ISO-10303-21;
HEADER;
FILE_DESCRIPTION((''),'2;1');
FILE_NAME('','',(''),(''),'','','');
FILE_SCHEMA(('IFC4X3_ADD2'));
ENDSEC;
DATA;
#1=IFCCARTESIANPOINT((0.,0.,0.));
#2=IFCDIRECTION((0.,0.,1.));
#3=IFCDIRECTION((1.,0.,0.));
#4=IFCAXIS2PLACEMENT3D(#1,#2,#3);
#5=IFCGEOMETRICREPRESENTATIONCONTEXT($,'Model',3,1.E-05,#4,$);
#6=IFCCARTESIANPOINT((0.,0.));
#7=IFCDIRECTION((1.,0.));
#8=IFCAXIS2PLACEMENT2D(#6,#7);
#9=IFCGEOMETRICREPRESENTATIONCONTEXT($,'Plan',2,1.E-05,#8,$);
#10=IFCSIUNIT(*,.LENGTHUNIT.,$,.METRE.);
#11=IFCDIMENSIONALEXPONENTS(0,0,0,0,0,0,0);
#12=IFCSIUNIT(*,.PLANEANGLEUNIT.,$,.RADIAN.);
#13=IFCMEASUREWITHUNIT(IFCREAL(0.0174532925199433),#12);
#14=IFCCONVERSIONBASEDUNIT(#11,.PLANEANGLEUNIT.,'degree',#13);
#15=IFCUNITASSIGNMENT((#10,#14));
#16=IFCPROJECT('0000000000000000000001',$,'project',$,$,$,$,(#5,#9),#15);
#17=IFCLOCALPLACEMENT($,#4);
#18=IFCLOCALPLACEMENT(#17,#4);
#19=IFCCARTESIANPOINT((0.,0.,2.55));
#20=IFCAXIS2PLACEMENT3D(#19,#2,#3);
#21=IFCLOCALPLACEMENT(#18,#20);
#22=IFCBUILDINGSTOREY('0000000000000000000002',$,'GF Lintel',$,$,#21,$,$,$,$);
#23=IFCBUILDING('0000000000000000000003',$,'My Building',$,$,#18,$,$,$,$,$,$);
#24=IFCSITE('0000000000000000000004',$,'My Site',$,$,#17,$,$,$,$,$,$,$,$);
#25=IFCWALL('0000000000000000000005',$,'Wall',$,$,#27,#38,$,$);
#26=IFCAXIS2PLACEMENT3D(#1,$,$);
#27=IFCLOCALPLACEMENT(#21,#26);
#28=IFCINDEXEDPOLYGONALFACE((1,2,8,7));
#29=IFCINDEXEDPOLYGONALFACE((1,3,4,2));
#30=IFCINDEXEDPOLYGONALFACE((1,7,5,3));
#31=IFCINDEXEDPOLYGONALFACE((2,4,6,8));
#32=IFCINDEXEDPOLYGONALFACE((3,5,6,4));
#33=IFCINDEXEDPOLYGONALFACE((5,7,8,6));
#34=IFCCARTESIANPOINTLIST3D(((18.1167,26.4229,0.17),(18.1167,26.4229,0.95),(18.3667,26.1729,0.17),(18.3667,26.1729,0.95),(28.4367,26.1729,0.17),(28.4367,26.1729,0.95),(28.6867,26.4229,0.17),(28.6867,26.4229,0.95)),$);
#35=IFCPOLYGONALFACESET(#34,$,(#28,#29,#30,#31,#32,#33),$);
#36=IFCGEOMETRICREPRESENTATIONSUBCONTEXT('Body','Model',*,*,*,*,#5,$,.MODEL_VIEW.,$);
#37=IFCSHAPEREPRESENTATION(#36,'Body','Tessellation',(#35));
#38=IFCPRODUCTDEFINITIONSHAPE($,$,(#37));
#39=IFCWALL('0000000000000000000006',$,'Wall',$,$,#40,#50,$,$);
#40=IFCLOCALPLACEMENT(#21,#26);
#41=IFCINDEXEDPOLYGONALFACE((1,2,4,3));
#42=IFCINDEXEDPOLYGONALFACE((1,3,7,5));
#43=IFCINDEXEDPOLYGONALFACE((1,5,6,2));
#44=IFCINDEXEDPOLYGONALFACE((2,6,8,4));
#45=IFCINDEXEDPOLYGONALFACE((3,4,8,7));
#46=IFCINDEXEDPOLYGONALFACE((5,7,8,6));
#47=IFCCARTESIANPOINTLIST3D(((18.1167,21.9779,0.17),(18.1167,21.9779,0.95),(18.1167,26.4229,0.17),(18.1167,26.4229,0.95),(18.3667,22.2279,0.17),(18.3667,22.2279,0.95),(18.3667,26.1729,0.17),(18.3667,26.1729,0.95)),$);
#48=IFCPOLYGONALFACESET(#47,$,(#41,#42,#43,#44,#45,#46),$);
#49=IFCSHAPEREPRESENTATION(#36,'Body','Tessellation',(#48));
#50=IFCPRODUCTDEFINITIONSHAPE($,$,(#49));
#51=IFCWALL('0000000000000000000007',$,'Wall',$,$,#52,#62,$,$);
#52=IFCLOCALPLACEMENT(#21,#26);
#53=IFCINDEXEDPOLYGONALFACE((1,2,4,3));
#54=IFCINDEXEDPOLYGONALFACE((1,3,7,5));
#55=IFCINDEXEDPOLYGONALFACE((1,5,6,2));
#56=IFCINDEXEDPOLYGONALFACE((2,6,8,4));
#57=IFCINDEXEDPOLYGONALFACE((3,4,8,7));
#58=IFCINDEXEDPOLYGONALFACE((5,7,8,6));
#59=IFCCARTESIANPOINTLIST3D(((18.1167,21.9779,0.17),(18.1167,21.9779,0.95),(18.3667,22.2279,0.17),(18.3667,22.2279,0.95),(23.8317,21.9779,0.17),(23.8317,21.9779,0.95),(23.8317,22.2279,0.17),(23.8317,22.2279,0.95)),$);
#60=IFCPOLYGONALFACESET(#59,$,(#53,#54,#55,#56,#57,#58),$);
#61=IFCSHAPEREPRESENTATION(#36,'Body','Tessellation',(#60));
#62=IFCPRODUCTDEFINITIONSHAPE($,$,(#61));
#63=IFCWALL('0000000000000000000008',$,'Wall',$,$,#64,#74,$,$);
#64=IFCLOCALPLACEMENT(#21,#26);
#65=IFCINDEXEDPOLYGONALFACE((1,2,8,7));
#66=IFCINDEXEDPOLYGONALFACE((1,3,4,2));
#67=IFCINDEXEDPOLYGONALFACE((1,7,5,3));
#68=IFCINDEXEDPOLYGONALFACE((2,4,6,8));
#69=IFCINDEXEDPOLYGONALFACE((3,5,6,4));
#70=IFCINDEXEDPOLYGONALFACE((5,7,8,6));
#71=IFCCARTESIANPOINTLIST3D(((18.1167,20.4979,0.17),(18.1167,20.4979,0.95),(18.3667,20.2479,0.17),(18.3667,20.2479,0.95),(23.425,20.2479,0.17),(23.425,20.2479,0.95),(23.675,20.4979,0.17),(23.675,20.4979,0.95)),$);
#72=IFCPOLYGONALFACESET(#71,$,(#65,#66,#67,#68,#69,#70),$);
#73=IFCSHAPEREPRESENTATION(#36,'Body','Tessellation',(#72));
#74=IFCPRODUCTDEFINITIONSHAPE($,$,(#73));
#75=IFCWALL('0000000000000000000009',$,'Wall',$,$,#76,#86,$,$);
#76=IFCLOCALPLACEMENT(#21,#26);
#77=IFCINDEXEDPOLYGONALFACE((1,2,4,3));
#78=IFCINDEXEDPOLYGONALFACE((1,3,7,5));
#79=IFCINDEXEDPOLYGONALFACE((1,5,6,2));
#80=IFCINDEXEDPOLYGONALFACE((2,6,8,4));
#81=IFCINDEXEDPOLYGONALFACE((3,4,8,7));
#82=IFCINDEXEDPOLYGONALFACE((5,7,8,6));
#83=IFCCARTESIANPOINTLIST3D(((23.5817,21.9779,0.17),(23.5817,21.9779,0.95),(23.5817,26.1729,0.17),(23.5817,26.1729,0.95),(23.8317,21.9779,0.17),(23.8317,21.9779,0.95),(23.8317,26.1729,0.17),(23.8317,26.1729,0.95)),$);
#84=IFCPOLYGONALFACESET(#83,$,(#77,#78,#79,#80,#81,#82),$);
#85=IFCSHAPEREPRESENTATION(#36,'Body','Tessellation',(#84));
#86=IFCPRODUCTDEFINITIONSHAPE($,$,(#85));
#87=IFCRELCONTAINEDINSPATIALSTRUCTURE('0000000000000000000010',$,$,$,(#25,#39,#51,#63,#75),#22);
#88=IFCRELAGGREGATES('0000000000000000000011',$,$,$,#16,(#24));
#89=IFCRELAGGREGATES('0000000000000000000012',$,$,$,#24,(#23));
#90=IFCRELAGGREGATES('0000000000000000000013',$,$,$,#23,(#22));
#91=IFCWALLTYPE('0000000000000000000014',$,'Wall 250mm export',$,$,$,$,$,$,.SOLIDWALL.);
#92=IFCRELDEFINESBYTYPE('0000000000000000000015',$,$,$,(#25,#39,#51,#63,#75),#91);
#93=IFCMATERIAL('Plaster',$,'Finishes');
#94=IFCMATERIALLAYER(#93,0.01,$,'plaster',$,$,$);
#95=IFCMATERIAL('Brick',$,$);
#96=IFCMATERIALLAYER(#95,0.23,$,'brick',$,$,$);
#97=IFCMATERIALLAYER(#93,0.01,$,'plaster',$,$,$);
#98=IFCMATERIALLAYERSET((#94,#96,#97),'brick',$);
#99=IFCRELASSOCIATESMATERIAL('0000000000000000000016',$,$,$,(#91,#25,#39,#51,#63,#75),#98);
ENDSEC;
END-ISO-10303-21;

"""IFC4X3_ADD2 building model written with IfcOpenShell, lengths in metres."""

from ifc_helpers import new_model, entity, si_unit, converted_unit, frame, origin_with_axes, origin_2d_with_axis, place, context, subcontext, project, spatial, line, indexed_curve, outline, extrude, material, layer, layer_set, layer_usage, type_object, element, save


model = new_model("IFC4X3_ADD2")

# Units and contexts
model_context = context("Model", 3, precision=1e-05, world=origin_with_axes())
plan_context = context("Plan", 2, precision=1e-05, world=origin_2d_with_axis())
body_context = subcontext(model_context, "Body", "Model", "MODEL_VIEW")
ifc_project = project(units=[si_unit("LENGTHUNIT", "METRE"), converted_unit("PLANEANGLEUNIT", "degree", entity("IfcReal", 0.0174532925199433), si_unit("PLANEANGLEUNIT", "RADIAN"), dimensions=[0, 0, 0, 0, 0, 0, 0])], contexts=[model_context, plan_context])

# Site, building, storey
site_placement = place(None, origin_with_axes())
site = spatial("IfcSite", under=ifc_project, at=site_placement, Name="My Site")
building_placement = place(site_placement, origin_with_axes())
building = spatial("IfcBuilding", under=site, at=building_placement, Name="My Building")
storey_placement = place(building_placement, frame((0.0, 0.0, 2.55), z_axis=(0.0, 0.0, 1.0), x_axis=(1.0, 0.0, 0.0)))
storey = spatial("IfcBuildingStorey", under=building, at=storey_placement, Name="GF Lintel")

# Walls
ifc_material_1 = material(Name="Plaster", Category="Finishes")
ifc_layer_1 = layer(ifc_material_1, 0.01, Name="plaster")
ifc_material_2 = material(Name="Brick")
ifc_layer_2 = layer(ifc_material_2, 0.23, Name="brick")
ifc_layer_3 = layer(ifc_material_1, 0.01, Name="plaster")
ifc_layer_set_1 = layer_set([ifc_layer_1, ifc_layer_2, ifc_layer_3], Name="brick")
wall_type_1 = type_object("IfcWallType", Name="Wall 250mm export", PredefinedType="SOLIDWALL", material=ifc_layer_set_1)
ifc_layer_usage_1 = layer_usage(ifc_layer_set_1, "AXIS2", "POSITIVE", 0.0)
wall_1_placement = place(storey_placement, frame((18.3667, 26.1729, 0.17), z_axis=(0.0, 0.0, 1.0), x_axis=(1.0, 0.0, 0.0)))
element("IfcWall", 1, at=wall_1_placement, inside=storey, type_object=wall_type_1, material=ifc_layer_usage_1, Name="Wall", context=body_context, shape_type="SweptSolid", body=[
    extrude(outline(indexed_curve([(0.0, 0.0), (-0.25, 0.25), (10.32, 0.25), (10.07, 0.0)], segments=[line(1, 2, 3, 4, 1)])), origin_with_axes(), (0.0, 0.0, 1.0), 0.78),
])
ifc_layer_usage_2 = layer_usage(ifc_layer_set_1, "AXIS2", "POSITIVE", 0.0)
wall_2_placement = place(storey_placement, frame((18.3667, 21.9779, 0.17), z_axis=(0.0, 0.0, 1.0), x_axis=(0.0, 1.0, 0.0)))
element("IfcWall", 2, at=wall_2_placement, inside=storey, type_object=wall_type_1, material=ifc_layer_usage_2, Name="Wall", context=body_context, shape_type="SweptSolid", body=[
    extrude(outline(indexed_curve([(0.25, 0.0), (0.0, 0.25), (4.445, 0.25), (4.195, 0.0)], segments=[line(1, 2, 3, 4, 1)])), origin_with_axes(), (0.0, 0.0, 1.0), 0.78),
])
ifc_layer_usage_3 = layer_usage(ifc_layer_set_1, "AXIS2", "POSITIVE", 0.0)
wall_3_placement = place(storey_placement, frame((18.3667, 21.9779, 0.17), z_axis=(0.0, 0.0, 1.0), x_axis=(1.0, 0.0, 0.0)))
element("IfcWall", 3, at=wall_3_placement, inside=storey, type_object=wall_type_1, material=ifc_layer_usage_3, Name="Wall", context=body_context, shape_type="SweptSolid", body=[
    extrude(outline(indexed_curve([(-0.25, 0.0), (0.0, 0.25), (5.465, 0.25), (5.465, 0.0)], segments=[line(1, 2, 3, 4, 1)])), origin_with_axes(), (0.0, 0.0, 1.0), 0.78),
])
ifc_layer_usage_4 = layer_usage(ifc_layer_set_1, "AXIS2", "POSITIVE", 0.0)
wall_4_placement = place(storey_placement, frame((18.1167, 20.2479, 0.17), z_axis=(0.0, 0.0, 1.0), x_axis=(1.0, 0.0, 0.0)))
element("IfcWall", 4, at=wall_4_placement, inside=storey, type_object=wall_type_1, material=ifc_layer_usage_4, Name="Wall", context=body_context, shape_type="SweptSolid", body=[
    extrude(outline(indexed_curve([(0.25, 0.0), (0.0, 0.25), (5.5583, 0.25), (5.3083, 0.0)], segments=[line(1, 2, 3, 4, 1)])), origin_with_axes(), (0.0, 0.0, 1.0), 0.78),
])
ifc_layer_usage_5 = layer_usage(ifc_layer_set_1, "AXIS2", "POSITIVE", 0.0)
wall_5_placement = place(storey_placement, frame((23.8317, 21.9779, 0.17), z_axis=(0.0, 0.0, 1.0), x_axis=(0.0, 1.0, 0.0)))
element("IfcWall", 5, at=wall_5_placement, inside=storey, type_object=wall_type_1, material=ifc_layer_usage_5, Name="Wall", context=body_context, shape_type="SweptSolid", body=[
    extrude(outline(indexed_curve([(0.0, 0.0), (0.0, 0.25), (4.195, 0.25), (4.195, 0.0)], segments=[line(1, 2, 3, 4, 1)])), origin_with_axes(), (0.0, 0.0, 1.0), 0.78),
])

save(model, "model.ifc")
